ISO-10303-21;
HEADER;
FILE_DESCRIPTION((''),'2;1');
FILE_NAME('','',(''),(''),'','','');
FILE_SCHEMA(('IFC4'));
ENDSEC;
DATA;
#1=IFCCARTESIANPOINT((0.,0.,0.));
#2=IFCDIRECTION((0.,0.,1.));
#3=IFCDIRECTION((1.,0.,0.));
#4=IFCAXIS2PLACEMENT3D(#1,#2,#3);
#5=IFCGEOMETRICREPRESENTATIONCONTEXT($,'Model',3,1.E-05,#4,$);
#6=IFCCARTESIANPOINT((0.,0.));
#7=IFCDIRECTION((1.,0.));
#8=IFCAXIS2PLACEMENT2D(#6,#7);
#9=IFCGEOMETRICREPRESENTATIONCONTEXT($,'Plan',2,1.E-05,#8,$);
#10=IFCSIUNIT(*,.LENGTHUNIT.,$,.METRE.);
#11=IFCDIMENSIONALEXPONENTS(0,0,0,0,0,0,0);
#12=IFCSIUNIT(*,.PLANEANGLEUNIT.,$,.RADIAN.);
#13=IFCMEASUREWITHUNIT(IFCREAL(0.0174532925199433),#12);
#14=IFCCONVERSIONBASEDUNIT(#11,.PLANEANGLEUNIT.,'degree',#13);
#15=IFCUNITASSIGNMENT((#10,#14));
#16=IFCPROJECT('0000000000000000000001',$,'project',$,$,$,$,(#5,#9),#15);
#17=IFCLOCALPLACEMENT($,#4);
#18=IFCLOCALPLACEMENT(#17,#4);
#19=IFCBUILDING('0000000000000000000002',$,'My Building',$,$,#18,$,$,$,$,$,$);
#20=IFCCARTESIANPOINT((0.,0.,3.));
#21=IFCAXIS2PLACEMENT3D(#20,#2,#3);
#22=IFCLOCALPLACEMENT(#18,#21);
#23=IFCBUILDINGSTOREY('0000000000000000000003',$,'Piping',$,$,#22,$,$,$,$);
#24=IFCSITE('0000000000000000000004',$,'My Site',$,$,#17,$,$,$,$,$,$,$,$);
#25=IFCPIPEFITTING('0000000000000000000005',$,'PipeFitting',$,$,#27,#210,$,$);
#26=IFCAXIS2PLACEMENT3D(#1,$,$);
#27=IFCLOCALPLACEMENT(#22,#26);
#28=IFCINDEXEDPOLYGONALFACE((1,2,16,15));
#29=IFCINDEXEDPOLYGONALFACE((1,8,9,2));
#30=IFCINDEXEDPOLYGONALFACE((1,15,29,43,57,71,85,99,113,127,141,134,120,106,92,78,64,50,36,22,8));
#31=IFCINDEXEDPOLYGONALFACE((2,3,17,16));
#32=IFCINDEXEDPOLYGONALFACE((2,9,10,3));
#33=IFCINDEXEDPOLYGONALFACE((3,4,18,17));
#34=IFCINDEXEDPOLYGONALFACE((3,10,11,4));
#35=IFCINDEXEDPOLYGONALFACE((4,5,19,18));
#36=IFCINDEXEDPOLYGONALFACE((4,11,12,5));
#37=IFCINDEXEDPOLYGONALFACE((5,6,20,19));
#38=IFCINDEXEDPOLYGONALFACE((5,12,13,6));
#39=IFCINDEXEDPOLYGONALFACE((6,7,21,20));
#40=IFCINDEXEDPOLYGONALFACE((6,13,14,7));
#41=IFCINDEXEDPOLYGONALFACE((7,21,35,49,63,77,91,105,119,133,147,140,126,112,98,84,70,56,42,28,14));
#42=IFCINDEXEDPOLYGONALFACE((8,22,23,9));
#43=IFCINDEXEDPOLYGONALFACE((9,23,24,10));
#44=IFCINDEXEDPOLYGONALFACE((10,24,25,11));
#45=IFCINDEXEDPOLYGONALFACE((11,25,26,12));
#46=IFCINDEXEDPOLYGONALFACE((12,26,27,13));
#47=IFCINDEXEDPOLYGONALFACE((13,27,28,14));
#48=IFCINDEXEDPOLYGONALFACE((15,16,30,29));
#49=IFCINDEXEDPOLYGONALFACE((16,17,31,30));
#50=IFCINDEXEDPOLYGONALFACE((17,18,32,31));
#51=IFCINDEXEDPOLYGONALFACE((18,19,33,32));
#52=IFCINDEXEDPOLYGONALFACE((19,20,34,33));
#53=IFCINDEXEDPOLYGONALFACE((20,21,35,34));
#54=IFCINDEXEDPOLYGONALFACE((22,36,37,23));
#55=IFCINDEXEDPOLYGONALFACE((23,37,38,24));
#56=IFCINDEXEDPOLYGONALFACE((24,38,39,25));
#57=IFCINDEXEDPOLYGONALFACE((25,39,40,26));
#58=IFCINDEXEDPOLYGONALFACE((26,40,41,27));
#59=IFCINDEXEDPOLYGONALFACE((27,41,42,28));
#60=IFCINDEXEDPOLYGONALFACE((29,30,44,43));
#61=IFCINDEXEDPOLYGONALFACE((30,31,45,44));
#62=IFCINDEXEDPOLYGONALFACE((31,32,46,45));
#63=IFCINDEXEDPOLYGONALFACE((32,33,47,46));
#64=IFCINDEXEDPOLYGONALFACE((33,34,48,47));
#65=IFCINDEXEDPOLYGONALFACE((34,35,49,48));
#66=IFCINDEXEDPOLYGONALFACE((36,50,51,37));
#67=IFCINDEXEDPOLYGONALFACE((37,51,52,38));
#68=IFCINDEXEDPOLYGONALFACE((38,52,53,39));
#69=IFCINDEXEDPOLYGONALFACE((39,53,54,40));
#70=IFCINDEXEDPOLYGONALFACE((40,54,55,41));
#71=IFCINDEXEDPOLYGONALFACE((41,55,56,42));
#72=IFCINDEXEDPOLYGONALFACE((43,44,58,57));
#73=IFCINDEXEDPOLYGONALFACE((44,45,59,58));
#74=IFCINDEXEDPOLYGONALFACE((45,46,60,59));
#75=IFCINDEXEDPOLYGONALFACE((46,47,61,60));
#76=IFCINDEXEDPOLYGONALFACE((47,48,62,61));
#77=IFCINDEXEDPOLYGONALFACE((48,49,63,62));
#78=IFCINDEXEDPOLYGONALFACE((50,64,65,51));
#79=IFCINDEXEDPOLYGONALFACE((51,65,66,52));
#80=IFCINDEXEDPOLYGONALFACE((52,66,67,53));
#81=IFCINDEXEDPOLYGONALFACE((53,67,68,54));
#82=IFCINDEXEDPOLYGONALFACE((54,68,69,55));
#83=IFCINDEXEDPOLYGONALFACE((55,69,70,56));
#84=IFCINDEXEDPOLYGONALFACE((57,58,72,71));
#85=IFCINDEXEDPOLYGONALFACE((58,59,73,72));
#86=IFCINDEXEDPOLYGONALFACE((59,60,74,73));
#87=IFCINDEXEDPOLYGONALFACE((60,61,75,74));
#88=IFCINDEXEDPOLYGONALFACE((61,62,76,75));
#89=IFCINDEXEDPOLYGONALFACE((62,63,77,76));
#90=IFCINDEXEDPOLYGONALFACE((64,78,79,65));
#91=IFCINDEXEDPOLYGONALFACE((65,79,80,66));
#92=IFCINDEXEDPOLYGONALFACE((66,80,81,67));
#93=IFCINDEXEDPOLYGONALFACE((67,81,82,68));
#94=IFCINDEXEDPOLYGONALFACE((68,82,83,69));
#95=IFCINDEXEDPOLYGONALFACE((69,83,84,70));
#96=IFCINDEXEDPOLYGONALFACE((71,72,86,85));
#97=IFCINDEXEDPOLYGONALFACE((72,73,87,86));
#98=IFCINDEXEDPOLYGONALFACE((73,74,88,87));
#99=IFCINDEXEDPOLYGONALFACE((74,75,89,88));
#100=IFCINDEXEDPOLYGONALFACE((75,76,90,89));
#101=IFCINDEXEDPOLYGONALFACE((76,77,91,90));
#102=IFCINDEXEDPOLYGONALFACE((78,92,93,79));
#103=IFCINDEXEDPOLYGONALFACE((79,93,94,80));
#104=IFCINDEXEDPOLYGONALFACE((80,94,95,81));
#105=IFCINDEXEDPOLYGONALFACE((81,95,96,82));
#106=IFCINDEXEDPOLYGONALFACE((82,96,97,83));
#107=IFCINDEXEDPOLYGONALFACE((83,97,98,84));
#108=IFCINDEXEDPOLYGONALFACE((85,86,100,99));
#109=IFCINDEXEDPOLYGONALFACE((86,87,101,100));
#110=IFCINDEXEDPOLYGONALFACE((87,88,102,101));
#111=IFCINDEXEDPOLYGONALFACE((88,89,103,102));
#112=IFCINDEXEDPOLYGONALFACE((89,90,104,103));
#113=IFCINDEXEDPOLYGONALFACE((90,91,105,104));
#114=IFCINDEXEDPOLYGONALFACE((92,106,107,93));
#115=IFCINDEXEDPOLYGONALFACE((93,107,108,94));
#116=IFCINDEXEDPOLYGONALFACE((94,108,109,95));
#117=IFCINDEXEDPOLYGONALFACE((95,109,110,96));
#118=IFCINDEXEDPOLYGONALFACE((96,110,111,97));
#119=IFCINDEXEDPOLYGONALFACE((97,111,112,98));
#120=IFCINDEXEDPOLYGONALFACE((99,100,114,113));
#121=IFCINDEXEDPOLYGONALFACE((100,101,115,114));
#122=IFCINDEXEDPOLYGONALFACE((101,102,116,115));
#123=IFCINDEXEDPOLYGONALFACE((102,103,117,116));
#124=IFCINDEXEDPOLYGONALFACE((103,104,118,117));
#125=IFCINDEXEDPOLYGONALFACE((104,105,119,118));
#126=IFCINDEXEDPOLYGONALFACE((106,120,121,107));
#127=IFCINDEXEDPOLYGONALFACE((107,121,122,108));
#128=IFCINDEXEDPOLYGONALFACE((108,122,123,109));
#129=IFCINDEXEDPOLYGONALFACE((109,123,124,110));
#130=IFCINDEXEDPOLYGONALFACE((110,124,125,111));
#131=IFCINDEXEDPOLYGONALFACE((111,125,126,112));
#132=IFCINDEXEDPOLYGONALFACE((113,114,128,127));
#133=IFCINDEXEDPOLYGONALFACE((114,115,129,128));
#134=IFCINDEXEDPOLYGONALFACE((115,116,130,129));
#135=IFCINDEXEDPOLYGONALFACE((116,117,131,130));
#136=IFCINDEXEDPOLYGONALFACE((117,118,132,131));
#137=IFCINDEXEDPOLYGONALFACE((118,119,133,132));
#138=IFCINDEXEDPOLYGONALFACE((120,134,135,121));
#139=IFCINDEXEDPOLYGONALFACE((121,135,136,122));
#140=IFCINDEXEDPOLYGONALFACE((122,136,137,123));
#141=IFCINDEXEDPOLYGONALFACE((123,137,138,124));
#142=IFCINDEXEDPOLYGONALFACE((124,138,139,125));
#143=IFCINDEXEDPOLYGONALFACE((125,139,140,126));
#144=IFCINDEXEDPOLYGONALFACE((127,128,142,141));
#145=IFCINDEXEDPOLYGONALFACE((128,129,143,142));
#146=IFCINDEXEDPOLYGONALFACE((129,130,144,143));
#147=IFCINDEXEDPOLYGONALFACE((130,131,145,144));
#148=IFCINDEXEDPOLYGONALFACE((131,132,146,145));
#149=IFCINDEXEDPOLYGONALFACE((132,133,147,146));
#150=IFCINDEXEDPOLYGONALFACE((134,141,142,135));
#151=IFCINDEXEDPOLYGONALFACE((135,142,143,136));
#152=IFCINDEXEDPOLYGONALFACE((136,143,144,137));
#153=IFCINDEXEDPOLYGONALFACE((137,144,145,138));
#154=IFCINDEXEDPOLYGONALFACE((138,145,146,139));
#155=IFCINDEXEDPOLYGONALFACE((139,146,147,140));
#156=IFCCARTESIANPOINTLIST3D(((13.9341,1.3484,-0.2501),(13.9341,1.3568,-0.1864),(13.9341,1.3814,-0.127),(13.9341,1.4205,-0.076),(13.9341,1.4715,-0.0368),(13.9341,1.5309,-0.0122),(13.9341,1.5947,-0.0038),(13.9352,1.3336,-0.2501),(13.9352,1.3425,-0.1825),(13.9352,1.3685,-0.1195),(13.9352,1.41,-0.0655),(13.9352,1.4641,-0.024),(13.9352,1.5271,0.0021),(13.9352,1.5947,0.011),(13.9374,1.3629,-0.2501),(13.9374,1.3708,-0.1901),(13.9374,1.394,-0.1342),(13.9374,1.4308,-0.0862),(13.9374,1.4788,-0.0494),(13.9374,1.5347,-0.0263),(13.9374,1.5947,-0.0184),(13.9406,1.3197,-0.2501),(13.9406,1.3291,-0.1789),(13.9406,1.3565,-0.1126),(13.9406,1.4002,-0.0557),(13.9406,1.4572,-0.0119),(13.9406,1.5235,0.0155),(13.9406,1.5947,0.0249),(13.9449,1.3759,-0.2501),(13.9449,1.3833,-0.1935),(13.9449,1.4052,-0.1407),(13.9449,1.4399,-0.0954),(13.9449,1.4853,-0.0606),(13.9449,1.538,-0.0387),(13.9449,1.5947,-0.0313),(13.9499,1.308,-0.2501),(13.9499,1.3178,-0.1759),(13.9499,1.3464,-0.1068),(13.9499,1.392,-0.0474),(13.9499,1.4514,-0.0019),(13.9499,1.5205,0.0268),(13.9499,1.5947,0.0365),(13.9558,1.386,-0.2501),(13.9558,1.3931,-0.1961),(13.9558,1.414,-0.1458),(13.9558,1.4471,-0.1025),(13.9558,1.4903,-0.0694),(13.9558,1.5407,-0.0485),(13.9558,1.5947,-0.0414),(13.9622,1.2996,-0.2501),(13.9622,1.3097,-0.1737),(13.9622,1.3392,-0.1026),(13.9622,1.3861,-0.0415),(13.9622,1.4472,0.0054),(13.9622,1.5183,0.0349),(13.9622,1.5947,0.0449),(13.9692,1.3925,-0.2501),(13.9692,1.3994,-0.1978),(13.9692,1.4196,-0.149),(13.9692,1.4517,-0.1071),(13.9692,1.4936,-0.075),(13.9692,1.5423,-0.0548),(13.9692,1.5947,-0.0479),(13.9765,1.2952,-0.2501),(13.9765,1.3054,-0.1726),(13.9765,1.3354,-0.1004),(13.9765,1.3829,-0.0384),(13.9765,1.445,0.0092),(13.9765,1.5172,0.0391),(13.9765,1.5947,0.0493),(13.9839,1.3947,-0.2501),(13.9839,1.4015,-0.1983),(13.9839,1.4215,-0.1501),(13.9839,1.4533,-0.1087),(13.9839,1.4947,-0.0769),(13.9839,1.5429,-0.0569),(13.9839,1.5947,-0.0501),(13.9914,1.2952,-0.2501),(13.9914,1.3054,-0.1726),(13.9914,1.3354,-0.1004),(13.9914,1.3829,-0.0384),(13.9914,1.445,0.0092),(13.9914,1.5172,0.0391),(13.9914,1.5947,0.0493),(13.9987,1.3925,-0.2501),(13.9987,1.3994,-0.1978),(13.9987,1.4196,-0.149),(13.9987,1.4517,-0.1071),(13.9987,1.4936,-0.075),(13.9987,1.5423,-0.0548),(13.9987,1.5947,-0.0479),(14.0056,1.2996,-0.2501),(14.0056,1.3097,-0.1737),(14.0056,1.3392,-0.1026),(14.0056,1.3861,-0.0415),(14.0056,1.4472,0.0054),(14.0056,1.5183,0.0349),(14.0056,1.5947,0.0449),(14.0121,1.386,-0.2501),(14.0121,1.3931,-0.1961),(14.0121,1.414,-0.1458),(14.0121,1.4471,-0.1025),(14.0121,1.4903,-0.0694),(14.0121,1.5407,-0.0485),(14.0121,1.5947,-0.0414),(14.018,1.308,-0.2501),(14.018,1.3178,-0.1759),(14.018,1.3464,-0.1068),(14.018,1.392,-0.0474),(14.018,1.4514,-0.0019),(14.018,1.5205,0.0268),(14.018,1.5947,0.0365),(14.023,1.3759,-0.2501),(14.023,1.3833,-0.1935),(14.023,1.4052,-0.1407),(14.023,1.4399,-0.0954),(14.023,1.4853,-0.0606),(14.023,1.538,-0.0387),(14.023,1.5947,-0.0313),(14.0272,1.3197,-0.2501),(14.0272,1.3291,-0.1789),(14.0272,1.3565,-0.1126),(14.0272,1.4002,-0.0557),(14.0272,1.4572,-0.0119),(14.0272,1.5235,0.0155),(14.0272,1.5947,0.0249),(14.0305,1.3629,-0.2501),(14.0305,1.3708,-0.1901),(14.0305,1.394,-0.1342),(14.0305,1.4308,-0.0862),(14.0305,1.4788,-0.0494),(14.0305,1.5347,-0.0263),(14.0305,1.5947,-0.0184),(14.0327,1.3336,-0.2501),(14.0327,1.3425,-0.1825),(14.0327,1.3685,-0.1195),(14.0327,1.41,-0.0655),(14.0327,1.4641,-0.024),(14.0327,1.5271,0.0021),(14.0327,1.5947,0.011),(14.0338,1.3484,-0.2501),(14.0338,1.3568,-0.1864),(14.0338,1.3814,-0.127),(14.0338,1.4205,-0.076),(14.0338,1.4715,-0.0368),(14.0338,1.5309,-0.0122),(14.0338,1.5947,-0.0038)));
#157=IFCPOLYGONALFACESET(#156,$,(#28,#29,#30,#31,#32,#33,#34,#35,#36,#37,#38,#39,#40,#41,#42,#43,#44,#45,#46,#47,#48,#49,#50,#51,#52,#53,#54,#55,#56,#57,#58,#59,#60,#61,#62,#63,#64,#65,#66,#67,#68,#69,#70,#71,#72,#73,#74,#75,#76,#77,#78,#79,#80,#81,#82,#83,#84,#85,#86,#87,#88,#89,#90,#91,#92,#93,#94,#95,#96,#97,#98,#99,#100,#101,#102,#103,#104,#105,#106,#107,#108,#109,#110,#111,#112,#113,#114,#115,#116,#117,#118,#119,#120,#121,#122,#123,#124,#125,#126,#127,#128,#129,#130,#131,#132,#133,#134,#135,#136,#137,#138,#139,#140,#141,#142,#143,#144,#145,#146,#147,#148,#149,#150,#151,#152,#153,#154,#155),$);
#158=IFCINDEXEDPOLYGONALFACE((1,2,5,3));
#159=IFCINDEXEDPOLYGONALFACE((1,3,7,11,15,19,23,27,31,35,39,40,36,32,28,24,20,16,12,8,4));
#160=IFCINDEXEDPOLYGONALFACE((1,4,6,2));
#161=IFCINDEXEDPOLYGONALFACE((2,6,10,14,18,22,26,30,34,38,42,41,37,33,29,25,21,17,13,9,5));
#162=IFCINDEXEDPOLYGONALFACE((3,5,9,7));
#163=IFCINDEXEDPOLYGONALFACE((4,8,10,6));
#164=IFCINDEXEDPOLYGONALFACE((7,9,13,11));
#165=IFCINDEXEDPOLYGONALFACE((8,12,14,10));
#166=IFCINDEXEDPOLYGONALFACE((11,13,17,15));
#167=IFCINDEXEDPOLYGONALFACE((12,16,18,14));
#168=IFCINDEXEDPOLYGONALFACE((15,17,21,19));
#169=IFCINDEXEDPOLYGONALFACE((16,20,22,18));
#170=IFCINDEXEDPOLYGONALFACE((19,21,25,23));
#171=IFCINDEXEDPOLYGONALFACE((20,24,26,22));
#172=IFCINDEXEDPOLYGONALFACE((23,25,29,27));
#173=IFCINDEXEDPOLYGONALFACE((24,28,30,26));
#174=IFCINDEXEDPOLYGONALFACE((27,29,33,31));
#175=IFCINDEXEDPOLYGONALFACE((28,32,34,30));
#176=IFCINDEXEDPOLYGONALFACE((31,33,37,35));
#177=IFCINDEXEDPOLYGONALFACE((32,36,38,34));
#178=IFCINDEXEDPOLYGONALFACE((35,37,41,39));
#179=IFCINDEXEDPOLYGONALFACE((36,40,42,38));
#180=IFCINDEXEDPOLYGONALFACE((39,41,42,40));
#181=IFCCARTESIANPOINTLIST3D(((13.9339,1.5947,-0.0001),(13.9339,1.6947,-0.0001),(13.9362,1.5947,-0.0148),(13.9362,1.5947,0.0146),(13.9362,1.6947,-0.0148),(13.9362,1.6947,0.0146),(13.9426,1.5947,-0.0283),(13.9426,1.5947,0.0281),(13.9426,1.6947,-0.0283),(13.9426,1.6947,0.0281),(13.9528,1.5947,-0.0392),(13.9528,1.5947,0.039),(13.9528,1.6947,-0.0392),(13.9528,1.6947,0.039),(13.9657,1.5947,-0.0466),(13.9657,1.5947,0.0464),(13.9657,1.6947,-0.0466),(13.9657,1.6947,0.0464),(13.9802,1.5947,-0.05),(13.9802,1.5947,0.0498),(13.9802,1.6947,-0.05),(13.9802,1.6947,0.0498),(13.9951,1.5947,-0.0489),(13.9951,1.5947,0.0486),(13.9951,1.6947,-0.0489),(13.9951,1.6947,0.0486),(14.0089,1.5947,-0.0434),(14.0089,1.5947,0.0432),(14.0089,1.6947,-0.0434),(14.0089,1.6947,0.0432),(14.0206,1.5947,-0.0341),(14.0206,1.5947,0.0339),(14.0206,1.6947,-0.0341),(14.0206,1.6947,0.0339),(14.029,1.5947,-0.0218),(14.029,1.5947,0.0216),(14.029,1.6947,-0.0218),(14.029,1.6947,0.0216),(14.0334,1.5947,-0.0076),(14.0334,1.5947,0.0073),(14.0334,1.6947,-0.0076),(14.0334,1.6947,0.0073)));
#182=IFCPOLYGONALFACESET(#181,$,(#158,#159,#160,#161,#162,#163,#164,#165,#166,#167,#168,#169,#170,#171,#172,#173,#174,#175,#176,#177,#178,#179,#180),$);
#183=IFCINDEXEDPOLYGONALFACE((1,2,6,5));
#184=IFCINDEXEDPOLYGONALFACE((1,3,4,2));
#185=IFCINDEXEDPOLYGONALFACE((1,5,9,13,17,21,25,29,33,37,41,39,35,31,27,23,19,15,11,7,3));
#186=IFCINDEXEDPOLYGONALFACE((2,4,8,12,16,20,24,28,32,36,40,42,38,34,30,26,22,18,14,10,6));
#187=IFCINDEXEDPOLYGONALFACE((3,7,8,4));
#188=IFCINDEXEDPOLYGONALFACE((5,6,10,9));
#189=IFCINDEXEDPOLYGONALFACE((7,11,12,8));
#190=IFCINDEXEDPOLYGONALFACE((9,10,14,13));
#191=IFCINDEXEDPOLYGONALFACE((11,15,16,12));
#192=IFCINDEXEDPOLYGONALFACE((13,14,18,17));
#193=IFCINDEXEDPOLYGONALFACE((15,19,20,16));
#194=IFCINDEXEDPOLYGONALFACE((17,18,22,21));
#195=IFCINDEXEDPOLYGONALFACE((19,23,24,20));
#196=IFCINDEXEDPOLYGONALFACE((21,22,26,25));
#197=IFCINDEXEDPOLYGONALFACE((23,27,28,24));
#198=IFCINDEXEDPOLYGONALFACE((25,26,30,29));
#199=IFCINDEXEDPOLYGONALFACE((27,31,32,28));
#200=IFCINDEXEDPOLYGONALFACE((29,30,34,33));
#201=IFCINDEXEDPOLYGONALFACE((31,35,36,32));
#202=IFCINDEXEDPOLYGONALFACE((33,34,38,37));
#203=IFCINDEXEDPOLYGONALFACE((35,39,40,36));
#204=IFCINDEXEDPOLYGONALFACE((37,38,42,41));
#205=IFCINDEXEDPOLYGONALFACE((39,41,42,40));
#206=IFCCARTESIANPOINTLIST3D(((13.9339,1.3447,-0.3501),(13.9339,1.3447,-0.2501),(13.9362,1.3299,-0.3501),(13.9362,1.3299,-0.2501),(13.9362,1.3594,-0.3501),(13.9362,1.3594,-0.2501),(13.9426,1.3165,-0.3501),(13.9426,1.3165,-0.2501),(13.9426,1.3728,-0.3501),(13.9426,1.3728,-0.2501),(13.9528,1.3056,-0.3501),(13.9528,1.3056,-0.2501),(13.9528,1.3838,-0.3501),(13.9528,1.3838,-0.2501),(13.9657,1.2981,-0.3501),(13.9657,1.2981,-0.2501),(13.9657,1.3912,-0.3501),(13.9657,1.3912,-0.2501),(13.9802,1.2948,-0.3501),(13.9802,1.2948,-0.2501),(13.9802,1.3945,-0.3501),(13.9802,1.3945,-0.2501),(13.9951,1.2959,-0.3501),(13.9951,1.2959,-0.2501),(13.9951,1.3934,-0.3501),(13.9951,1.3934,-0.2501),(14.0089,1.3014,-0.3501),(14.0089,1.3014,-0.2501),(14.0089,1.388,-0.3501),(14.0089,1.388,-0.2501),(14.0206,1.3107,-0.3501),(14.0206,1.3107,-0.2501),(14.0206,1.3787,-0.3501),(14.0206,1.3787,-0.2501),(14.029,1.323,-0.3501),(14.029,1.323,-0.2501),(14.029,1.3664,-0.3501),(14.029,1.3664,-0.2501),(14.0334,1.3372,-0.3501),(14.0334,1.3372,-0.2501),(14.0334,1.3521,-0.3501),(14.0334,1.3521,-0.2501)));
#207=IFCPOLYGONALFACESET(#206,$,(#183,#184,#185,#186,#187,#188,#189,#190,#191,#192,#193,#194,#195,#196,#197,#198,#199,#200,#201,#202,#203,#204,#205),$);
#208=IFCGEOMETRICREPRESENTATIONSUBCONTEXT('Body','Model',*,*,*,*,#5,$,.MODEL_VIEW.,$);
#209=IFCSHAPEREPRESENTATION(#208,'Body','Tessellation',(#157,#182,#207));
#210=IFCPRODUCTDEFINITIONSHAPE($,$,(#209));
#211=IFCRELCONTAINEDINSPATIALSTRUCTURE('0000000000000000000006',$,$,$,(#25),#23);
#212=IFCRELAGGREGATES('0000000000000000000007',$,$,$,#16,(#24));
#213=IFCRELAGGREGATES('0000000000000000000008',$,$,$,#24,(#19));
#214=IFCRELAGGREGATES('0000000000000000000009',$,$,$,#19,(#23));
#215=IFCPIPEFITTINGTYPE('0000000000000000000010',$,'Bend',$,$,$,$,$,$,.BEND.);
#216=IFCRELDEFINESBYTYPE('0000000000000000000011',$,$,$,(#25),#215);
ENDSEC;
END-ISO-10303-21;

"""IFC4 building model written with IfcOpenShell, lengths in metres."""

from ifc_helpers import new_model, entity, si_unit, converted_unit, frame, origin_with_axes, origin_2d_with_axis, place, context, subcontext, project, spatial, circle, extrude, source, transform, mapped, type_object, type_shapes, element, save


model = new_model("IFC4")

# Units and contexts
model_context = context("Model", 3, precision=1e-05, world=origin_with_axes())
plan_context = context("Plan", 2, precision=1e-05, world=origin_2d_with_axis())
body_context = subcontext(model_context, "Body", "Model", "MODEL_VIEW")
ifc_project = project(units=[si_unit("LENGTHUNIT", "METRE"), converted_unit("PLANEANGLEUNIT", "degree", entity("IfcReal", 0.0174532925199433), si_unit("PLANEANGLEUNIT", "RADIAN"), dimensions=[0, 0, 0, 0, 0, 0, 0])], contexts=[model_context, plan_context])

# Site, building, storey
site_placement = place(None, origin_with_axes())
site = spatial("IfcSite", under=ifc_project, at=site_placement, Name="My Site")
building_placement = place(site_placement, origin_with_axes())
building = spatial("IfcBuilding", under=site, at=building_placement, Name="My Building")
storey_placement = place(building_placement, frame((0.0, 0.0, 3.0), z_axis=(0.0, 0.0, 1.0), x_axis=(1.0, 0.0, 0.0)))
storey = spatial("IfcBuildingStorey", under=building, at=storey_placement, Name="Piping")

# Pipe fitting
pipe_fitting_type = type_object("IfcPipeFittingType", Name="Bend", PredefinedType="BEND")
shared_shape = source(origin_with_axes(), body_context, "Body", "SolidModel", [
    entity("IfcSweptDiskSolid", entity("IfcIndexedPolyCurve", entity("IfcCartesianPointList3D", [[0.0, 0.0, -0.1], [0.0, -0.0732, -0.2768], [0.0, -0.25, -0.35]]), [entity("IfcArcIndex", [1, 2, 3])]), 0.05),
    extrude(circle(Radius=0.05), origin_with_axes(), (0.0, 0.0, -1.0), 0.1),
    extrude(circle(Radius=0.05), frame((0.0, -0.25, -0.35), z_axis=(0.0, -1.0, 0.0), x_axis=(1.0, 0.0, 0.0)), (0.0, 0.0, 1.0), 0.1),
])
type_shapes(pipe_fitting_type, [shared_shape])
for number, where, z_axis, x_axis, name in (
    (1, (13.9839, 1.6947, -0.0001), (0.0, 1.0, 0.0), (-1.0, 0.0, 0.0), "PipeFitting"),
):
    element("IfcPipeFitting", number, at=place(storey_placement, frame(where, z_axis=z_axis, x_axis=x_axis)), inside=storey, type_object=pipe_fitting_type, Name=name, context=body_context, shape_type="MappedRepresentation", body=[
        mapped(shared_shape, transform((0.0, 0.0, 0.0), x_axis=(1.0, 0.0, 0.0), y_axis=(0.0, 1.0, 0.0), z_axis=(0.0, 0.0, 1.0), scale=1.0)),
    ])

save(model, "model.ifc")
